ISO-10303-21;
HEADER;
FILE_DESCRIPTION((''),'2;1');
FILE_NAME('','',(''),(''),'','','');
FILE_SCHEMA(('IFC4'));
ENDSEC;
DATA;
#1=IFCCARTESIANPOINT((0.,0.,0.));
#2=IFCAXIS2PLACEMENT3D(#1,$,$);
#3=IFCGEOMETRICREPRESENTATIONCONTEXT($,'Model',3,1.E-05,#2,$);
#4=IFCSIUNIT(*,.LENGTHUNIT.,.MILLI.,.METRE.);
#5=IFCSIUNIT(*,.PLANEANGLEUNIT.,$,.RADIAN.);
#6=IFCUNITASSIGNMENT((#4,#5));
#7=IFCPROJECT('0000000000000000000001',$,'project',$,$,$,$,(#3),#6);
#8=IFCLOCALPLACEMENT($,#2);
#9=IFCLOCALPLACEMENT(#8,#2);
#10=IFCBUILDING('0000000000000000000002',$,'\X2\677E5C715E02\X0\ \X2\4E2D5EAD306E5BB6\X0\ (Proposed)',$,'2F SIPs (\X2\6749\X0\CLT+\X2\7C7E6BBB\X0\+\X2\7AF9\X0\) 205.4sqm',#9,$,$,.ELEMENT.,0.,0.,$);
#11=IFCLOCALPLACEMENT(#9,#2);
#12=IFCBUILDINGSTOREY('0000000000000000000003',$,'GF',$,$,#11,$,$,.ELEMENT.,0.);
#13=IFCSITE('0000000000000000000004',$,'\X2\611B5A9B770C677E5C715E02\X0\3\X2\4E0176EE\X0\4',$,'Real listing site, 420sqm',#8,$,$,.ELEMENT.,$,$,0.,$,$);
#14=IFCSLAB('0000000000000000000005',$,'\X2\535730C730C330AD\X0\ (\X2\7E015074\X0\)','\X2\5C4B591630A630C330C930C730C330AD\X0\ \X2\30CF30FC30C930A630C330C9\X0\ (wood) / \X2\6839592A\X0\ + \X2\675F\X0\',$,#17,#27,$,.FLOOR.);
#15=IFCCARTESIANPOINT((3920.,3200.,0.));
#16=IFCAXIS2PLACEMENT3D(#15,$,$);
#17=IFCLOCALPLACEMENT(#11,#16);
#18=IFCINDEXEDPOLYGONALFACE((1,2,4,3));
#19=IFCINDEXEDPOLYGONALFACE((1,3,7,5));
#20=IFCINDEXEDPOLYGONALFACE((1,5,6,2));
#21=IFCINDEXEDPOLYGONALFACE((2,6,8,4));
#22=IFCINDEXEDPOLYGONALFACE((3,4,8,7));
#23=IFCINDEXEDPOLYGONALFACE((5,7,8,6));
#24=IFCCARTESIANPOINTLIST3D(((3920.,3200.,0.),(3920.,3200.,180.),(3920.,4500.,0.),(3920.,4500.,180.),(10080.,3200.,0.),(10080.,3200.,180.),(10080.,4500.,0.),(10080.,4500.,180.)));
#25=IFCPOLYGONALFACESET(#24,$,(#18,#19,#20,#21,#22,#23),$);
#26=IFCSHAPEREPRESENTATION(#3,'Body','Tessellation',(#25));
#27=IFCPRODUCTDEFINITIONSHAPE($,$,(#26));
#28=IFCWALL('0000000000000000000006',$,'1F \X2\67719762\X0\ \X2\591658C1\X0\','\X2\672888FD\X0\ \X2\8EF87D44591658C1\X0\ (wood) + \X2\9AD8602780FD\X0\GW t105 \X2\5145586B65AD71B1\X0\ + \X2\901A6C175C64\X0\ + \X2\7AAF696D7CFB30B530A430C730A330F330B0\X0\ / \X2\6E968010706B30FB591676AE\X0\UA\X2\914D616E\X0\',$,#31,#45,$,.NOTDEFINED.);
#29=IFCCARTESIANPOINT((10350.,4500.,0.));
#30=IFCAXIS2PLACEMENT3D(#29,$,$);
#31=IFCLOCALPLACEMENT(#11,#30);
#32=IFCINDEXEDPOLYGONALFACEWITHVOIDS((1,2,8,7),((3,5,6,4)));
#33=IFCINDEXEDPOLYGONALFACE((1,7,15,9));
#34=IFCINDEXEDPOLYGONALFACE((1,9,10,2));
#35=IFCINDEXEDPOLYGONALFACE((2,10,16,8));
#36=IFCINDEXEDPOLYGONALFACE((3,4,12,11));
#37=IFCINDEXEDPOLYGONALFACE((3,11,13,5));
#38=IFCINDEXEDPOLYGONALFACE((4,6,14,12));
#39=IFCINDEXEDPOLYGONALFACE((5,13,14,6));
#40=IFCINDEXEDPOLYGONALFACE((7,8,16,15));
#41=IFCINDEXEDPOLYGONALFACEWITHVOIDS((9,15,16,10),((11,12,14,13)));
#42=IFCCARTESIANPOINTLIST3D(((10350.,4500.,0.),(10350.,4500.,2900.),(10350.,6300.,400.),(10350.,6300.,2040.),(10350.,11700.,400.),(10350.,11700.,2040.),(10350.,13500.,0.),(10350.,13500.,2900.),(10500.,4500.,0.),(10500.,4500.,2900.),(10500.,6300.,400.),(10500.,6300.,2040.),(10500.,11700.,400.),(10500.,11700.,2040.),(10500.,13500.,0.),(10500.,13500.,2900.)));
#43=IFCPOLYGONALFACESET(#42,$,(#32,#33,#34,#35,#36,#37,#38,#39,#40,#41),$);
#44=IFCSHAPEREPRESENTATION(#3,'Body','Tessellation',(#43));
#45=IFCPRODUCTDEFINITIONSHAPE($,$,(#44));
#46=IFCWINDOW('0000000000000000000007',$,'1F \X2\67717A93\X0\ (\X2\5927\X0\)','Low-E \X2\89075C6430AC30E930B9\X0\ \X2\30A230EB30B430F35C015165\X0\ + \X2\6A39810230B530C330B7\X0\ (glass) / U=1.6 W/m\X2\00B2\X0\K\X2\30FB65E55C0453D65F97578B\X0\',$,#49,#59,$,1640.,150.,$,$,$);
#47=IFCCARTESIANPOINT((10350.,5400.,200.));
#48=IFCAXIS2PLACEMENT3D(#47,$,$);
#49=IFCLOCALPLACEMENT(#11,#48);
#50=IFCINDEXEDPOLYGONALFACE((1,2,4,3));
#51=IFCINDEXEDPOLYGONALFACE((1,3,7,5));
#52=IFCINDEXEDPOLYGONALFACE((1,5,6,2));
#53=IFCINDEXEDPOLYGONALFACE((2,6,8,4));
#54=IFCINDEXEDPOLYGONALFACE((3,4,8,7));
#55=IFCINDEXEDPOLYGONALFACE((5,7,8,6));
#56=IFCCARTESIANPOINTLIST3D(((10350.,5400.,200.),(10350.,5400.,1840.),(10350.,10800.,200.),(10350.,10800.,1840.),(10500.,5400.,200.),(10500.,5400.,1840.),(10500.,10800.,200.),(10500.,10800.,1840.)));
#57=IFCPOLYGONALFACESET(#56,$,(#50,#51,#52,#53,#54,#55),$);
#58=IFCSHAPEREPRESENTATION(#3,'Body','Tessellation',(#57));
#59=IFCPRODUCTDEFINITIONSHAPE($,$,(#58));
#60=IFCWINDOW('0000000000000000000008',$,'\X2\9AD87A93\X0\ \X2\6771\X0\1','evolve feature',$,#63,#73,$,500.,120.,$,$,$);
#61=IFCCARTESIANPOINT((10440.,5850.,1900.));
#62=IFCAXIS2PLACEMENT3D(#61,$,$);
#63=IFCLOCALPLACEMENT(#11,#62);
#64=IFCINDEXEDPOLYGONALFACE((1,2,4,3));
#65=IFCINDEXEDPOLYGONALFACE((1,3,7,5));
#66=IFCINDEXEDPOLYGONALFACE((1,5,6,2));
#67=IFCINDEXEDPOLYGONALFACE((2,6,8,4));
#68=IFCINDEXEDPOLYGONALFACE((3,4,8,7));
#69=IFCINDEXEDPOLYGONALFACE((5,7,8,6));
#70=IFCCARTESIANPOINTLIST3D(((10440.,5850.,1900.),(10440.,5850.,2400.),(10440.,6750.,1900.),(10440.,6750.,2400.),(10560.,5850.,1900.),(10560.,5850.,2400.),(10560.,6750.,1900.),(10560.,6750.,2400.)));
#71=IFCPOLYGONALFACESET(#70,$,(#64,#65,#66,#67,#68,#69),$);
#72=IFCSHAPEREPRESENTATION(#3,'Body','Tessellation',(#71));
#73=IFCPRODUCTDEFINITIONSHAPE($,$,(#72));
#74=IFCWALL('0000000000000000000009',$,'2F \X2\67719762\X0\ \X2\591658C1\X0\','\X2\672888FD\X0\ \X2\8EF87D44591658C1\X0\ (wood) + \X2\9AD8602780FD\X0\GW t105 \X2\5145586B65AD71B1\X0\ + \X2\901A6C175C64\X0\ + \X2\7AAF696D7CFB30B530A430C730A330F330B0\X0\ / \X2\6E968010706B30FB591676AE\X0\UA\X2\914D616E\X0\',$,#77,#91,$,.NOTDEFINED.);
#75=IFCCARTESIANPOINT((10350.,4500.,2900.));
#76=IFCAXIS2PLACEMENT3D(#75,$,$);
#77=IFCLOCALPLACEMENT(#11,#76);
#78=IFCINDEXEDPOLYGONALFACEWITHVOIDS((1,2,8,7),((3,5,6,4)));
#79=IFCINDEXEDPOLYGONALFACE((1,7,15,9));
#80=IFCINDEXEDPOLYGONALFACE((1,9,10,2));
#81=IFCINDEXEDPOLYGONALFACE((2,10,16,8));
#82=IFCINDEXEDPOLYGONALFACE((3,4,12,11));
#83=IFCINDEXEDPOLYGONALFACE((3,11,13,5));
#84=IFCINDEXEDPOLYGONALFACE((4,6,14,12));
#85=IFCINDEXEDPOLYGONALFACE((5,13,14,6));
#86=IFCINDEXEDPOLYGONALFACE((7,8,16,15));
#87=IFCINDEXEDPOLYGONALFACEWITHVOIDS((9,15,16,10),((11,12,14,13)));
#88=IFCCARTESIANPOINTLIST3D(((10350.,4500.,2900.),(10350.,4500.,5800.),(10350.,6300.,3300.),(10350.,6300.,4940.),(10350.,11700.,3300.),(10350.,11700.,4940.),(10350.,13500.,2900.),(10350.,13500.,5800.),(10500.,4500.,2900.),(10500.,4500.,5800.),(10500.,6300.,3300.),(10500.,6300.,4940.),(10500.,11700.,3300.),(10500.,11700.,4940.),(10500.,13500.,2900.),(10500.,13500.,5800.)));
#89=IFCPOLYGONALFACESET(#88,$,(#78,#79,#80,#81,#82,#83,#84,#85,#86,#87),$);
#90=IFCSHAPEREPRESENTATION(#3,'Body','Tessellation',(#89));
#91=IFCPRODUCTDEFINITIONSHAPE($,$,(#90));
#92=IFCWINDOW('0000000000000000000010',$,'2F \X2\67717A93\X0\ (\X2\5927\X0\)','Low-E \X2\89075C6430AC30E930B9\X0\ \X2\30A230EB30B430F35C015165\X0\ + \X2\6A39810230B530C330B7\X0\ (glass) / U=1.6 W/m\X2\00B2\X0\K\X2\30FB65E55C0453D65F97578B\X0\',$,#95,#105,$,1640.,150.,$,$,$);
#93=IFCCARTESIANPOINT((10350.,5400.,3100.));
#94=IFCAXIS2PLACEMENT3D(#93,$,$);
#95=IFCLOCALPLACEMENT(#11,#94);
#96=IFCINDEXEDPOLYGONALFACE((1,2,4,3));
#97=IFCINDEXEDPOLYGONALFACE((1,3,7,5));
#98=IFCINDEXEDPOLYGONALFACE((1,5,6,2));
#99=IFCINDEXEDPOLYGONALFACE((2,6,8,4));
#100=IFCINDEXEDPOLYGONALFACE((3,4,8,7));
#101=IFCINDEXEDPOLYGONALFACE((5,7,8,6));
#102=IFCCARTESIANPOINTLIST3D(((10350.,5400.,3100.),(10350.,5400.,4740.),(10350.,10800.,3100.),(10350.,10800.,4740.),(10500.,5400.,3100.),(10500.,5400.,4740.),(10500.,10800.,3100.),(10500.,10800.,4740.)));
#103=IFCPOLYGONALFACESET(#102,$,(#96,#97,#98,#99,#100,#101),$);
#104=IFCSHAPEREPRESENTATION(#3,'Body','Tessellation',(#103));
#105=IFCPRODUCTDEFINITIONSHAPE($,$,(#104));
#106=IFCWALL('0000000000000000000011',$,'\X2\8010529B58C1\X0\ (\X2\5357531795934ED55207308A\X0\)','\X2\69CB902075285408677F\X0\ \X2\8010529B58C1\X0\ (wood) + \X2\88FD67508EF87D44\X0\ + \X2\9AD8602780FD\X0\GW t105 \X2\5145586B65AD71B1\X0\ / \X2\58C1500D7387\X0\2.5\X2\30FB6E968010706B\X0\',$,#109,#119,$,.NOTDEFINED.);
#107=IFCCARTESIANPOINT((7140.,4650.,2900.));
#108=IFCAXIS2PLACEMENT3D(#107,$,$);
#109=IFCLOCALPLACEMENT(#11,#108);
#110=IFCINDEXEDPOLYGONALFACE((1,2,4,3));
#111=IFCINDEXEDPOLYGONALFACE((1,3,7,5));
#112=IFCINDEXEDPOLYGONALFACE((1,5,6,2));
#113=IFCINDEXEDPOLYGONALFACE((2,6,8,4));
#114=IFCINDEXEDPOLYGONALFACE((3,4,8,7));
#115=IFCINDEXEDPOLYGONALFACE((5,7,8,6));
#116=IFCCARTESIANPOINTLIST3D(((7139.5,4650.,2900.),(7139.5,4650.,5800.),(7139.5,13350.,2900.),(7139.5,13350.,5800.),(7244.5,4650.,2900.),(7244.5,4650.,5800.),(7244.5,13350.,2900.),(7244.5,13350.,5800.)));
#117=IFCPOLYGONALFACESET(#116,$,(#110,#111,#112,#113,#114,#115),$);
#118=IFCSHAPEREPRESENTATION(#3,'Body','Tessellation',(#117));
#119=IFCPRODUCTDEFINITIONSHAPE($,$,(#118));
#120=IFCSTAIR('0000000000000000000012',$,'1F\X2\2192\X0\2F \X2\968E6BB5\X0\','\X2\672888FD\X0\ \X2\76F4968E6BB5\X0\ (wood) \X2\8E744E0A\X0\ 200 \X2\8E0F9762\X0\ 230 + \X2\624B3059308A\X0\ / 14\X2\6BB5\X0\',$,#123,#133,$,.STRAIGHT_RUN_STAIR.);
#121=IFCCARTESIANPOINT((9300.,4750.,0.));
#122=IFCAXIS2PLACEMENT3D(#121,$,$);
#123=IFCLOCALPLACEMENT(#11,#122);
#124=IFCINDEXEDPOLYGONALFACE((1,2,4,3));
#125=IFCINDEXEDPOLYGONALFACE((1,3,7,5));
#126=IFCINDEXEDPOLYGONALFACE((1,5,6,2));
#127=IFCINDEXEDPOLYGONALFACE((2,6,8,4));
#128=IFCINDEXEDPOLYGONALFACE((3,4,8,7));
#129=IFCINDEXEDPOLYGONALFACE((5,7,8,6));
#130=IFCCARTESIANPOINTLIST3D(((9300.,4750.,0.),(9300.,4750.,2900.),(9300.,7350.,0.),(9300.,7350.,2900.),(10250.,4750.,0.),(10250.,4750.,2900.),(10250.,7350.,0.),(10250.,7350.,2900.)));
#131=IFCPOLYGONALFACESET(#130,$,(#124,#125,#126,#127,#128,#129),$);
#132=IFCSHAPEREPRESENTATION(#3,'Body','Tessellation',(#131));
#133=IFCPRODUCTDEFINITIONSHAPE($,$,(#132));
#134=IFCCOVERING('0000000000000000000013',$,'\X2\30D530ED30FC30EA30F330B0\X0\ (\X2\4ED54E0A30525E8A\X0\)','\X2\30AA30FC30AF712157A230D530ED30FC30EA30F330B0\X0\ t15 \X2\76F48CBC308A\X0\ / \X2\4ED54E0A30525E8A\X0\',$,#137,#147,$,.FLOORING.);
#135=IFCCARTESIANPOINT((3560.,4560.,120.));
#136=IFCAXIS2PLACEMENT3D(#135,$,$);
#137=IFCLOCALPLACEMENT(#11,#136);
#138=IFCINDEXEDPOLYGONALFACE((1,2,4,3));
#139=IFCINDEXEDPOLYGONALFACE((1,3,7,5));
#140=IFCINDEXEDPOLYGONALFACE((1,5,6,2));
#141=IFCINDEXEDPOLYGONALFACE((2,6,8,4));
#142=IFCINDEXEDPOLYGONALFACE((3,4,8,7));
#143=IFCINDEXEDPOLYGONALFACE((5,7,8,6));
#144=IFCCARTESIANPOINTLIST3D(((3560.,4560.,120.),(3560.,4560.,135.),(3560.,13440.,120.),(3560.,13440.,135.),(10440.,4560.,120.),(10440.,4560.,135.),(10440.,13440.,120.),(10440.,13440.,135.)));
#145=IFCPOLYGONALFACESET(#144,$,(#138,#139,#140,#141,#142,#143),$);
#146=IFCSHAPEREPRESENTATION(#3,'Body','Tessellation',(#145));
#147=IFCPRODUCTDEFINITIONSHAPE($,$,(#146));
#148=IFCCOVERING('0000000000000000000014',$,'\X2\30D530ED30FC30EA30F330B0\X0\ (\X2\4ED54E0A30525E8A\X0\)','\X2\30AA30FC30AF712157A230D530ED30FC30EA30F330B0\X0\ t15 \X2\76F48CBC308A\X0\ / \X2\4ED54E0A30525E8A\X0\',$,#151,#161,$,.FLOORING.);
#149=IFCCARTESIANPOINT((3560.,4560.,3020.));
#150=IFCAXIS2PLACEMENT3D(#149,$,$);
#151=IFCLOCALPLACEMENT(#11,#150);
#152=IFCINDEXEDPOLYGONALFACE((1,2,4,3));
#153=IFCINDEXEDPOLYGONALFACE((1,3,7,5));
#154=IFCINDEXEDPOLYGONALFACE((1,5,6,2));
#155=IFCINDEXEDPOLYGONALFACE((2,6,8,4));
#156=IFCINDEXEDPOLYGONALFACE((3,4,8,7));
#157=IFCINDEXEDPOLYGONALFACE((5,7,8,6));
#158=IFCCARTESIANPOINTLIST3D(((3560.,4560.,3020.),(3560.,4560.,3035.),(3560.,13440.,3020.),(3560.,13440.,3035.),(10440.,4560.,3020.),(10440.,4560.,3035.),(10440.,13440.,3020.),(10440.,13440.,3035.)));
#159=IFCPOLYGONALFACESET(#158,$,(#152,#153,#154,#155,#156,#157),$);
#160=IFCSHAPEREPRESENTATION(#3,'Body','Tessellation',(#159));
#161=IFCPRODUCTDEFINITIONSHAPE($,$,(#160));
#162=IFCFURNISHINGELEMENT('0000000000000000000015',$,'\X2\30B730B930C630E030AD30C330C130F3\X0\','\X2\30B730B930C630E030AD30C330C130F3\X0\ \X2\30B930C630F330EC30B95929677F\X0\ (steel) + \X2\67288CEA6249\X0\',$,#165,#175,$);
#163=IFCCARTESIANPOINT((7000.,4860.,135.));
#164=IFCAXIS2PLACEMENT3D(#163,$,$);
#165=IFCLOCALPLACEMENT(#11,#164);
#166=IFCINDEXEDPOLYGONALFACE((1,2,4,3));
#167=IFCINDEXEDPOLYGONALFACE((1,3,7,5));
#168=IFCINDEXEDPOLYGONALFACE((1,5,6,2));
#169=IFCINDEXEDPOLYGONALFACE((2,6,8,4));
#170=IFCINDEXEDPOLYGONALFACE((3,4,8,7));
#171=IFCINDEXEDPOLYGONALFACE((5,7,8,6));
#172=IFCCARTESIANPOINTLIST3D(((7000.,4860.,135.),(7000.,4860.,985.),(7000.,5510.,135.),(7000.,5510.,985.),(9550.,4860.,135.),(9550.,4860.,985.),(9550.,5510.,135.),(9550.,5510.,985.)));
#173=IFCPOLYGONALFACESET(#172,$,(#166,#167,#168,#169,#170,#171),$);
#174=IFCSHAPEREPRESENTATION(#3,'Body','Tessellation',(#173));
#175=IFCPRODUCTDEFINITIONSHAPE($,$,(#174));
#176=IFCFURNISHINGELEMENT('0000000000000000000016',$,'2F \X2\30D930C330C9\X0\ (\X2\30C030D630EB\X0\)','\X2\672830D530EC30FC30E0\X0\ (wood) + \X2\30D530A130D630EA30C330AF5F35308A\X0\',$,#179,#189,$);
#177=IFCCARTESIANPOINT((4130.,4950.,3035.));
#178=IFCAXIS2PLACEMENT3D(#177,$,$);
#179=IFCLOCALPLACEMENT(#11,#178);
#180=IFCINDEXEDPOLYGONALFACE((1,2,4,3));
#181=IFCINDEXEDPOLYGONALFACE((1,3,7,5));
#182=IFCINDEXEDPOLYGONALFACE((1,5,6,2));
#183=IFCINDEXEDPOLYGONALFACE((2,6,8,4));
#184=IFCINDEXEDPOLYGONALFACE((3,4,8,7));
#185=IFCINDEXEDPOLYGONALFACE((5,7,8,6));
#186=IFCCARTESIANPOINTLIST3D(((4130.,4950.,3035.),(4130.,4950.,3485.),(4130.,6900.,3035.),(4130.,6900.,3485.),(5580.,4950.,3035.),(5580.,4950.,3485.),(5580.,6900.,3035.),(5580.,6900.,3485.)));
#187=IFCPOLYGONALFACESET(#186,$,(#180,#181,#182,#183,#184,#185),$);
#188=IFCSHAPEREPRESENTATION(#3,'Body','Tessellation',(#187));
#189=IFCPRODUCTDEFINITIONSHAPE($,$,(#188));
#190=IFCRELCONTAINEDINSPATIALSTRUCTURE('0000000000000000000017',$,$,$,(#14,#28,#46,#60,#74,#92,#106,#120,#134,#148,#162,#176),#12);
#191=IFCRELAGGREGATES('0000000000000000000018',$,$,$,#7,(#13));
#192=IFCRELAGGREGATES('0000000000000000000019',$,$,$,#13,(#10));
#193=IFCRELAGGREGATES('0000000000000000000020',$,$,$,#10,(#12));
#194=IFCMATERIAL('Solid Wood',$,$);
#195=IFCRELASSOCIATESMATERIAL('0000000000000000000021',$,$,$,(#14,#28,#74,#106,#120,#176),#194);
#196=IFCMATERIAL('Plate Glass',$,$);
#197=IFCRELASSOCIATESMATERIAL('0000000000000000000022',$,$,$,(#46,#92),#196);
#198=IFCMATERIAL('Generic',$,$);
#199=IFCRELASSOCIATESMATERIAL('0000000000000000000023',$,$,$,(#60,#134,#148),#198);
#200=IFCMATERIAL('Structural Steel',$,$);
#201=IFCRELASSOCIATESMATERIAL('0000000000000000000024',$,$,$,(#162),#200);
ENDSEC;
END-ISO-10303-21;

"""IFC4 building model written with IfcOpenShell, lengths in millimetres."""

from ifc_helpers import new_model, si_unit, frame, frame_2d, origin, place, context, project, spatial, rectangle, extrude, material, element, fill, save


model = new_model("IFC4")

# Units and contexts
model_context = context("Model", 3, precision=1e-05, world=origin())
ifc_project = project(units=[si_unit("LENGTHUNIT", "METRE", prefix="MILLI"), si_unit("PLANEANGLEUNIT", "RADIAN")], contexts=[model_context])

# Site, building, storey
site_placement = place(None, origin())
site = spatial("IfcSite", under=ifc_project, at=site_placement, Name="愛媛県松山市3丁目4", ObjectType="Real listing site, 420sqm", CompositionType="ELEMENT", RefElevation=0.0)
building_placement = place(site_placement, origin())
building = spatial("IfcBuilding", under=site, at=building_placement, Name="松山市 中庭の家 (Proposed)", ObjectType="2F SIPs (杉CLT+籾殻+竹) 205.4sqm", CompositionType="ELEMENT", ElevationOfRefHeight=0.0, ElevationOfTerrain=0.0)
storey_placement = place(building_placement, origin())
storey = spatial("IfcBuildingStorey", under=building, at=storey_placement, Name="GF", CompositionType="ELEMENT", Elevation=0.0)

# Slab
ifc_material_1 = material(Name="Solid Wood")
slab_placement = place(storey_placement, frame((3920.0, 3200.0, 0.0)))
element("IfcSlab", 1, at=slab_placement, inside=storey, material=ifc_material_1, Name="南デッキ (縁側)", Description="屋外ウッドデッキ ハードウッド (wood) / 根太 + 束", PredefinedType="FLOOR", context=model_context, shape_type="SweptSolid", body=[
    extrude(rectangle(XDim=6160.0, YDim=1300.0, at=frame_2d((3080.0, 650.0))), frame((3920.0, 3200.0, 0.0)), (0.0, 0.0, 1.0), 180.0),
])

# Wall, openings, windows
wall_1_placement = place(storey_placement, frame((10350.0, 4500.0, 0.0)))
wall_1 = element("IfcWall", 2, at=wall_1_placement, inside=storey, material=ifc_material_1, Name="1F 東面 外壁", Description="木製 軸組外壁 (wood) + 高性能GW t105 充填断熱 + 通気層 + 窯業系サイディング / 準耐火・外皮UA配慮", PredefinedType="NOTDEFINED", context=model_context, shape_type="SweptSolid", body=[
    extrude(rectangle(XDim=150.0, YDim=9000.0, at=frame_2d((75.0, 4500.0))), frame((10350.0, 4500.0, 0.0)), (0.0, 0.0, 1.0), 2900.0),
])
opening_1_placement = place(storey_placement, frame((10350.0, 5400.0, 200.0)))
opening_1 = element("IfcOpeningElement", 3, at=opening_1_placement, cuts=wall_1, PredefinedType="NOTDEFINED", context=model_context, shape_type="SweptSolid", body=[
    extrude(rectangle(XDim=150.0, YDim=5400.0, at=frame_2d((75.0, 2700.0))), frame((10350.0, 5400.0, 200.0)), (0.0, 0.0, 1.0), 1640.0),
])
opening_2_placement = place(storey_placement, frame((10440.0, 5850.0, 1900.0)))
opening_2 = element("IfcOpeningElement", 4, at=opening_2_placement, cuts=wall_1, PredefinedType="NOTDEFINED", context=model_context, shape_type="SweptSolid", body=[
    extrude(rectangle(XDim=120.0, YDim=900.0, at=frame_2d((60.0, 450.0))), frame((10440.0, 5850.0, 1900.0)), (0.0, 0.0, 1.0), 500.0),
])
ifc_material_2 = material(Name="Plate Glass")
window_1_placement = place(storey_placement, frame((10350.0, 5400.0, 200.0)))
window_1 = element("IfcWindow", 5, at=window_1_placement, inside=storey, material=ifc_material_2, Name="1F 東窓 (大)", Description="Low-E 複層ガラス アルゴン封入 + 樹脂サッシ (glass) / U=1.6 W/m²K・日射取得型", OverallHeight=1640.0, OverallWidth=150.0, context=model_context, shape_type="SweptSolid", body=[
    extrude(rectangle(XDim=150.0, YDim=5400.0, at=frame_2d((75.0, 2700.0))), frame((10350.0, 5400.0, 200.0)), (0.0, 0.0, 1.0), 1640.0),
])
fill(opening_1, window_1)
ifc_material_3 = material(Name="Generic")
window_2_placement = place(storey_placement, frame((10440.0, 5850.0, 1900.0)))
window_2 = element("IfcWindow", 6, at=window_2_placement, inside=storey, material=ifc_material_3, Name="高窓 東1", Description="evolve feature", OverallHeight=500.0, OverallWidth=120.0, context=model_context, shape_type="SweptSolid", body=[
    extrude(rectangle(XDim=120.0, YDim=900.0, at=frame_2d((60.0, 450.0))), frame((10440.0, 5850.0, 1900.0)), (0.0, 0.0, 1.0), 500.0),
])
fill(opening_2, window_2)

# Wall, opening, window
wall_2_placement = place(storey_placement, frame((10350.0, 4500.0, 2900.0)))
wall_2 = element("IfcWall", 7, at=wall_2_placement, inside=storey, material=ifc_material_1, Name="2F 東面 外壁", Description="木製 軸組外壁 (wood) + 高性能GW t105 充填断熱 + 通気層 + 窯業系サイディング / 準耐火・外皮UA配慮", PredefinedType="NOTDEFINED", context=model_context, shape_type="SweptSolid", body=[
    extrude(rectangle(XDim=150.0, YDim=9000.0, at=frame_2d((75.0, 4500.0))), frame((10350.0, 4500.0, 2900.0)), (0.0, 0.0, 1.0), 2900.0),
])
opening_3_placement = place(storey_placement, frame((10350.0, 5400.0, 3100.0)))
opening_3 = element("IfcOpeningElement", 8, at=opening_3_placement, cuts=wall_2, PredefinedType="NOTDEFINED", context=model_context, shape_type="SweptSolid", body=[
    extrude(rectangle(XDim=150.0, YDim=5400.0, at=frame_2d((75.0, 2700.0))), frame((10350.0, 5400.0, 3100.0)), (0.0, 0.0, 1.0), 1640.0),
])
window_3_placement = place(storey_placement, frame((10350.0, 5400.0, 3100.0)))
window_3 = element("IfcWindow", 9, at=window_3_placement, inside=storey, material=ifc_material_2, Name="2F 東窓 (大)", Description="Low-E 複層ガラス アルゴン封入 + 樹脂サッシ (glass) / U=1.6 W/m²K・日射取得型", OverallHeight=1640.0, OverallWidth=150.0, context=model_context, shape_type="SweptSolid", body=[
    extrude(rectangle(XDim=150.0, YDim=5400.0, at=frame_2d((75.0, 2700.0))), frame((10350.0, 5400.0, 3100.0)), (0.0, 0.0, 1.0), 1640.0),
])
fill(opening_3, window_3)

# Wall
wall_3_placement = place(storey_placement, frame((7140.0, 4650.0, 2900.0)))
element("IfcWall", 10, at=wall_3_placement, inside=storey, material=ifc_material_1, Name="耐力壁 (南北間仕切り)", Description="構造用合板 耐力壁 (wood) + 製材軸組 + 高性能GW t105 充填断熱 / 壁倍率2.5・準耐火", PredefinedType="NOTDEFINED", context=model_context, shape_type="SweptSolid", body=[
    extrude(rectangle(XDim=105.0, YDim=8700.0, at=frame_2d((52.0, 4350.0))), frame((7140.0, 4650.0, 2900.0)), (0.0, 0.0, 1.0), 2900.0),
])

# Stair
stair_placement = place(storey_placement, frame((9300.0, 4750.0, 0.0)))
element("IfcStair", 11, at=stair_placement, inside=storey, material=ifc_material_1, Name="1F→2F 階段", Description="木製 直階段 (wood) 蹴上 200 踏面 230 + 手すり / 14段", PredefinedType="STRAIGHT_RUN_STAIR", context=model_context, shape_type="SweptSolid", body=[
    extrude(rectangle(XDim=950.0, YDim=2600.0, at=frame_2d((475.0, 1300.0))), frame((9300.0, 4750.0, 0.0)), (0.0, 0.0, 1.0), 2900.0),
])

# Coverings
covering_1_placement = place(storey_placement, frame((3560.0, 4560.0, 120.0)))
element("IfcCovering", 12, at=covering_1_placement, inside=storey, material=ifc_material_3, Name="フローリング (仕上げ床)", Description="オーク無垢フローリング t15 直貼り / 仕上げ床", PredefinedType="FLOORING", context=model_context, shape_type="SweptSolid", body=[
    extrude(rectangle(XDim=6880.0, YDim=8880.0, at=frame_2d((3440.0, 4440.0))), frame((3560.0, 4560.0, 120.0)), (0.0, 0.0, 1.0), 15.0),
])
covering_2_placement = place(storey_placement, frame((3560.0, 4560.0, 3020.0)))
element("IfcCovering", 13, at=covering_2_placement, inside=storey, material=ifc_material_3, Name="フローリング (仕上げ床)", Description="オーク無垢フローリング t15 直貼り / 仕上げ床", PredefinedType="FLOORING", context=model_context, shape_type="SweptSolid", body=[
    extrude(rectangle(XDim=6880.0, YDim=8880.0, at=frame_2d((3440.0, 4440.0))), frame((3560.0, 4560.0, 3020.0)), (0.0, 0.0, 1.0), 15.0),
])

# Furnishing elements
ifc_material_4 = material(Name="Structural Steel")
furnishing_1_placement = place(storey_placement, frame((7000.0, 4860.0, 135.0)))
element("IfcFurnishingElement", 14, at=furnishing_1_placement, inside=storey, material=ifc_material_4, Name="システムキッチン", Description="システムキッチン ステンレス天板 (steel) + 木質扉", context=model_context, shape_type="SweptSolid", body=[
    extrude(rectangle(XDim=2550.0, YDim=650.0, at=frame_2d((1275.0, 325.0))), frame((7000.0, 4860.0, 135.0)), (0.0, 0.0, 1.0), 850.0),
])
furnishing_2_placement = place(storey_placement, frame((4130.0, 4950.0, 3035.0)))
element("IfcFurnishingElement", 15, at=furnishing_2_placement, inside=storey, material=ifc_material_1, Name="2F ベッド (ダブル)", Description="木フレーム (wood) + ファブリック張り", context=model_context, shape_type="SweptSolid", body=[
    extrude(rectangle(XDim=1450.0, YDim=1950.0, at=frame_2d((725.0, 975.0))), frame((4130.0, 4950.0, 3035.0)), (0.0, 0.0, 1.0), 450.0),
])

save(model, "model.ifc")
